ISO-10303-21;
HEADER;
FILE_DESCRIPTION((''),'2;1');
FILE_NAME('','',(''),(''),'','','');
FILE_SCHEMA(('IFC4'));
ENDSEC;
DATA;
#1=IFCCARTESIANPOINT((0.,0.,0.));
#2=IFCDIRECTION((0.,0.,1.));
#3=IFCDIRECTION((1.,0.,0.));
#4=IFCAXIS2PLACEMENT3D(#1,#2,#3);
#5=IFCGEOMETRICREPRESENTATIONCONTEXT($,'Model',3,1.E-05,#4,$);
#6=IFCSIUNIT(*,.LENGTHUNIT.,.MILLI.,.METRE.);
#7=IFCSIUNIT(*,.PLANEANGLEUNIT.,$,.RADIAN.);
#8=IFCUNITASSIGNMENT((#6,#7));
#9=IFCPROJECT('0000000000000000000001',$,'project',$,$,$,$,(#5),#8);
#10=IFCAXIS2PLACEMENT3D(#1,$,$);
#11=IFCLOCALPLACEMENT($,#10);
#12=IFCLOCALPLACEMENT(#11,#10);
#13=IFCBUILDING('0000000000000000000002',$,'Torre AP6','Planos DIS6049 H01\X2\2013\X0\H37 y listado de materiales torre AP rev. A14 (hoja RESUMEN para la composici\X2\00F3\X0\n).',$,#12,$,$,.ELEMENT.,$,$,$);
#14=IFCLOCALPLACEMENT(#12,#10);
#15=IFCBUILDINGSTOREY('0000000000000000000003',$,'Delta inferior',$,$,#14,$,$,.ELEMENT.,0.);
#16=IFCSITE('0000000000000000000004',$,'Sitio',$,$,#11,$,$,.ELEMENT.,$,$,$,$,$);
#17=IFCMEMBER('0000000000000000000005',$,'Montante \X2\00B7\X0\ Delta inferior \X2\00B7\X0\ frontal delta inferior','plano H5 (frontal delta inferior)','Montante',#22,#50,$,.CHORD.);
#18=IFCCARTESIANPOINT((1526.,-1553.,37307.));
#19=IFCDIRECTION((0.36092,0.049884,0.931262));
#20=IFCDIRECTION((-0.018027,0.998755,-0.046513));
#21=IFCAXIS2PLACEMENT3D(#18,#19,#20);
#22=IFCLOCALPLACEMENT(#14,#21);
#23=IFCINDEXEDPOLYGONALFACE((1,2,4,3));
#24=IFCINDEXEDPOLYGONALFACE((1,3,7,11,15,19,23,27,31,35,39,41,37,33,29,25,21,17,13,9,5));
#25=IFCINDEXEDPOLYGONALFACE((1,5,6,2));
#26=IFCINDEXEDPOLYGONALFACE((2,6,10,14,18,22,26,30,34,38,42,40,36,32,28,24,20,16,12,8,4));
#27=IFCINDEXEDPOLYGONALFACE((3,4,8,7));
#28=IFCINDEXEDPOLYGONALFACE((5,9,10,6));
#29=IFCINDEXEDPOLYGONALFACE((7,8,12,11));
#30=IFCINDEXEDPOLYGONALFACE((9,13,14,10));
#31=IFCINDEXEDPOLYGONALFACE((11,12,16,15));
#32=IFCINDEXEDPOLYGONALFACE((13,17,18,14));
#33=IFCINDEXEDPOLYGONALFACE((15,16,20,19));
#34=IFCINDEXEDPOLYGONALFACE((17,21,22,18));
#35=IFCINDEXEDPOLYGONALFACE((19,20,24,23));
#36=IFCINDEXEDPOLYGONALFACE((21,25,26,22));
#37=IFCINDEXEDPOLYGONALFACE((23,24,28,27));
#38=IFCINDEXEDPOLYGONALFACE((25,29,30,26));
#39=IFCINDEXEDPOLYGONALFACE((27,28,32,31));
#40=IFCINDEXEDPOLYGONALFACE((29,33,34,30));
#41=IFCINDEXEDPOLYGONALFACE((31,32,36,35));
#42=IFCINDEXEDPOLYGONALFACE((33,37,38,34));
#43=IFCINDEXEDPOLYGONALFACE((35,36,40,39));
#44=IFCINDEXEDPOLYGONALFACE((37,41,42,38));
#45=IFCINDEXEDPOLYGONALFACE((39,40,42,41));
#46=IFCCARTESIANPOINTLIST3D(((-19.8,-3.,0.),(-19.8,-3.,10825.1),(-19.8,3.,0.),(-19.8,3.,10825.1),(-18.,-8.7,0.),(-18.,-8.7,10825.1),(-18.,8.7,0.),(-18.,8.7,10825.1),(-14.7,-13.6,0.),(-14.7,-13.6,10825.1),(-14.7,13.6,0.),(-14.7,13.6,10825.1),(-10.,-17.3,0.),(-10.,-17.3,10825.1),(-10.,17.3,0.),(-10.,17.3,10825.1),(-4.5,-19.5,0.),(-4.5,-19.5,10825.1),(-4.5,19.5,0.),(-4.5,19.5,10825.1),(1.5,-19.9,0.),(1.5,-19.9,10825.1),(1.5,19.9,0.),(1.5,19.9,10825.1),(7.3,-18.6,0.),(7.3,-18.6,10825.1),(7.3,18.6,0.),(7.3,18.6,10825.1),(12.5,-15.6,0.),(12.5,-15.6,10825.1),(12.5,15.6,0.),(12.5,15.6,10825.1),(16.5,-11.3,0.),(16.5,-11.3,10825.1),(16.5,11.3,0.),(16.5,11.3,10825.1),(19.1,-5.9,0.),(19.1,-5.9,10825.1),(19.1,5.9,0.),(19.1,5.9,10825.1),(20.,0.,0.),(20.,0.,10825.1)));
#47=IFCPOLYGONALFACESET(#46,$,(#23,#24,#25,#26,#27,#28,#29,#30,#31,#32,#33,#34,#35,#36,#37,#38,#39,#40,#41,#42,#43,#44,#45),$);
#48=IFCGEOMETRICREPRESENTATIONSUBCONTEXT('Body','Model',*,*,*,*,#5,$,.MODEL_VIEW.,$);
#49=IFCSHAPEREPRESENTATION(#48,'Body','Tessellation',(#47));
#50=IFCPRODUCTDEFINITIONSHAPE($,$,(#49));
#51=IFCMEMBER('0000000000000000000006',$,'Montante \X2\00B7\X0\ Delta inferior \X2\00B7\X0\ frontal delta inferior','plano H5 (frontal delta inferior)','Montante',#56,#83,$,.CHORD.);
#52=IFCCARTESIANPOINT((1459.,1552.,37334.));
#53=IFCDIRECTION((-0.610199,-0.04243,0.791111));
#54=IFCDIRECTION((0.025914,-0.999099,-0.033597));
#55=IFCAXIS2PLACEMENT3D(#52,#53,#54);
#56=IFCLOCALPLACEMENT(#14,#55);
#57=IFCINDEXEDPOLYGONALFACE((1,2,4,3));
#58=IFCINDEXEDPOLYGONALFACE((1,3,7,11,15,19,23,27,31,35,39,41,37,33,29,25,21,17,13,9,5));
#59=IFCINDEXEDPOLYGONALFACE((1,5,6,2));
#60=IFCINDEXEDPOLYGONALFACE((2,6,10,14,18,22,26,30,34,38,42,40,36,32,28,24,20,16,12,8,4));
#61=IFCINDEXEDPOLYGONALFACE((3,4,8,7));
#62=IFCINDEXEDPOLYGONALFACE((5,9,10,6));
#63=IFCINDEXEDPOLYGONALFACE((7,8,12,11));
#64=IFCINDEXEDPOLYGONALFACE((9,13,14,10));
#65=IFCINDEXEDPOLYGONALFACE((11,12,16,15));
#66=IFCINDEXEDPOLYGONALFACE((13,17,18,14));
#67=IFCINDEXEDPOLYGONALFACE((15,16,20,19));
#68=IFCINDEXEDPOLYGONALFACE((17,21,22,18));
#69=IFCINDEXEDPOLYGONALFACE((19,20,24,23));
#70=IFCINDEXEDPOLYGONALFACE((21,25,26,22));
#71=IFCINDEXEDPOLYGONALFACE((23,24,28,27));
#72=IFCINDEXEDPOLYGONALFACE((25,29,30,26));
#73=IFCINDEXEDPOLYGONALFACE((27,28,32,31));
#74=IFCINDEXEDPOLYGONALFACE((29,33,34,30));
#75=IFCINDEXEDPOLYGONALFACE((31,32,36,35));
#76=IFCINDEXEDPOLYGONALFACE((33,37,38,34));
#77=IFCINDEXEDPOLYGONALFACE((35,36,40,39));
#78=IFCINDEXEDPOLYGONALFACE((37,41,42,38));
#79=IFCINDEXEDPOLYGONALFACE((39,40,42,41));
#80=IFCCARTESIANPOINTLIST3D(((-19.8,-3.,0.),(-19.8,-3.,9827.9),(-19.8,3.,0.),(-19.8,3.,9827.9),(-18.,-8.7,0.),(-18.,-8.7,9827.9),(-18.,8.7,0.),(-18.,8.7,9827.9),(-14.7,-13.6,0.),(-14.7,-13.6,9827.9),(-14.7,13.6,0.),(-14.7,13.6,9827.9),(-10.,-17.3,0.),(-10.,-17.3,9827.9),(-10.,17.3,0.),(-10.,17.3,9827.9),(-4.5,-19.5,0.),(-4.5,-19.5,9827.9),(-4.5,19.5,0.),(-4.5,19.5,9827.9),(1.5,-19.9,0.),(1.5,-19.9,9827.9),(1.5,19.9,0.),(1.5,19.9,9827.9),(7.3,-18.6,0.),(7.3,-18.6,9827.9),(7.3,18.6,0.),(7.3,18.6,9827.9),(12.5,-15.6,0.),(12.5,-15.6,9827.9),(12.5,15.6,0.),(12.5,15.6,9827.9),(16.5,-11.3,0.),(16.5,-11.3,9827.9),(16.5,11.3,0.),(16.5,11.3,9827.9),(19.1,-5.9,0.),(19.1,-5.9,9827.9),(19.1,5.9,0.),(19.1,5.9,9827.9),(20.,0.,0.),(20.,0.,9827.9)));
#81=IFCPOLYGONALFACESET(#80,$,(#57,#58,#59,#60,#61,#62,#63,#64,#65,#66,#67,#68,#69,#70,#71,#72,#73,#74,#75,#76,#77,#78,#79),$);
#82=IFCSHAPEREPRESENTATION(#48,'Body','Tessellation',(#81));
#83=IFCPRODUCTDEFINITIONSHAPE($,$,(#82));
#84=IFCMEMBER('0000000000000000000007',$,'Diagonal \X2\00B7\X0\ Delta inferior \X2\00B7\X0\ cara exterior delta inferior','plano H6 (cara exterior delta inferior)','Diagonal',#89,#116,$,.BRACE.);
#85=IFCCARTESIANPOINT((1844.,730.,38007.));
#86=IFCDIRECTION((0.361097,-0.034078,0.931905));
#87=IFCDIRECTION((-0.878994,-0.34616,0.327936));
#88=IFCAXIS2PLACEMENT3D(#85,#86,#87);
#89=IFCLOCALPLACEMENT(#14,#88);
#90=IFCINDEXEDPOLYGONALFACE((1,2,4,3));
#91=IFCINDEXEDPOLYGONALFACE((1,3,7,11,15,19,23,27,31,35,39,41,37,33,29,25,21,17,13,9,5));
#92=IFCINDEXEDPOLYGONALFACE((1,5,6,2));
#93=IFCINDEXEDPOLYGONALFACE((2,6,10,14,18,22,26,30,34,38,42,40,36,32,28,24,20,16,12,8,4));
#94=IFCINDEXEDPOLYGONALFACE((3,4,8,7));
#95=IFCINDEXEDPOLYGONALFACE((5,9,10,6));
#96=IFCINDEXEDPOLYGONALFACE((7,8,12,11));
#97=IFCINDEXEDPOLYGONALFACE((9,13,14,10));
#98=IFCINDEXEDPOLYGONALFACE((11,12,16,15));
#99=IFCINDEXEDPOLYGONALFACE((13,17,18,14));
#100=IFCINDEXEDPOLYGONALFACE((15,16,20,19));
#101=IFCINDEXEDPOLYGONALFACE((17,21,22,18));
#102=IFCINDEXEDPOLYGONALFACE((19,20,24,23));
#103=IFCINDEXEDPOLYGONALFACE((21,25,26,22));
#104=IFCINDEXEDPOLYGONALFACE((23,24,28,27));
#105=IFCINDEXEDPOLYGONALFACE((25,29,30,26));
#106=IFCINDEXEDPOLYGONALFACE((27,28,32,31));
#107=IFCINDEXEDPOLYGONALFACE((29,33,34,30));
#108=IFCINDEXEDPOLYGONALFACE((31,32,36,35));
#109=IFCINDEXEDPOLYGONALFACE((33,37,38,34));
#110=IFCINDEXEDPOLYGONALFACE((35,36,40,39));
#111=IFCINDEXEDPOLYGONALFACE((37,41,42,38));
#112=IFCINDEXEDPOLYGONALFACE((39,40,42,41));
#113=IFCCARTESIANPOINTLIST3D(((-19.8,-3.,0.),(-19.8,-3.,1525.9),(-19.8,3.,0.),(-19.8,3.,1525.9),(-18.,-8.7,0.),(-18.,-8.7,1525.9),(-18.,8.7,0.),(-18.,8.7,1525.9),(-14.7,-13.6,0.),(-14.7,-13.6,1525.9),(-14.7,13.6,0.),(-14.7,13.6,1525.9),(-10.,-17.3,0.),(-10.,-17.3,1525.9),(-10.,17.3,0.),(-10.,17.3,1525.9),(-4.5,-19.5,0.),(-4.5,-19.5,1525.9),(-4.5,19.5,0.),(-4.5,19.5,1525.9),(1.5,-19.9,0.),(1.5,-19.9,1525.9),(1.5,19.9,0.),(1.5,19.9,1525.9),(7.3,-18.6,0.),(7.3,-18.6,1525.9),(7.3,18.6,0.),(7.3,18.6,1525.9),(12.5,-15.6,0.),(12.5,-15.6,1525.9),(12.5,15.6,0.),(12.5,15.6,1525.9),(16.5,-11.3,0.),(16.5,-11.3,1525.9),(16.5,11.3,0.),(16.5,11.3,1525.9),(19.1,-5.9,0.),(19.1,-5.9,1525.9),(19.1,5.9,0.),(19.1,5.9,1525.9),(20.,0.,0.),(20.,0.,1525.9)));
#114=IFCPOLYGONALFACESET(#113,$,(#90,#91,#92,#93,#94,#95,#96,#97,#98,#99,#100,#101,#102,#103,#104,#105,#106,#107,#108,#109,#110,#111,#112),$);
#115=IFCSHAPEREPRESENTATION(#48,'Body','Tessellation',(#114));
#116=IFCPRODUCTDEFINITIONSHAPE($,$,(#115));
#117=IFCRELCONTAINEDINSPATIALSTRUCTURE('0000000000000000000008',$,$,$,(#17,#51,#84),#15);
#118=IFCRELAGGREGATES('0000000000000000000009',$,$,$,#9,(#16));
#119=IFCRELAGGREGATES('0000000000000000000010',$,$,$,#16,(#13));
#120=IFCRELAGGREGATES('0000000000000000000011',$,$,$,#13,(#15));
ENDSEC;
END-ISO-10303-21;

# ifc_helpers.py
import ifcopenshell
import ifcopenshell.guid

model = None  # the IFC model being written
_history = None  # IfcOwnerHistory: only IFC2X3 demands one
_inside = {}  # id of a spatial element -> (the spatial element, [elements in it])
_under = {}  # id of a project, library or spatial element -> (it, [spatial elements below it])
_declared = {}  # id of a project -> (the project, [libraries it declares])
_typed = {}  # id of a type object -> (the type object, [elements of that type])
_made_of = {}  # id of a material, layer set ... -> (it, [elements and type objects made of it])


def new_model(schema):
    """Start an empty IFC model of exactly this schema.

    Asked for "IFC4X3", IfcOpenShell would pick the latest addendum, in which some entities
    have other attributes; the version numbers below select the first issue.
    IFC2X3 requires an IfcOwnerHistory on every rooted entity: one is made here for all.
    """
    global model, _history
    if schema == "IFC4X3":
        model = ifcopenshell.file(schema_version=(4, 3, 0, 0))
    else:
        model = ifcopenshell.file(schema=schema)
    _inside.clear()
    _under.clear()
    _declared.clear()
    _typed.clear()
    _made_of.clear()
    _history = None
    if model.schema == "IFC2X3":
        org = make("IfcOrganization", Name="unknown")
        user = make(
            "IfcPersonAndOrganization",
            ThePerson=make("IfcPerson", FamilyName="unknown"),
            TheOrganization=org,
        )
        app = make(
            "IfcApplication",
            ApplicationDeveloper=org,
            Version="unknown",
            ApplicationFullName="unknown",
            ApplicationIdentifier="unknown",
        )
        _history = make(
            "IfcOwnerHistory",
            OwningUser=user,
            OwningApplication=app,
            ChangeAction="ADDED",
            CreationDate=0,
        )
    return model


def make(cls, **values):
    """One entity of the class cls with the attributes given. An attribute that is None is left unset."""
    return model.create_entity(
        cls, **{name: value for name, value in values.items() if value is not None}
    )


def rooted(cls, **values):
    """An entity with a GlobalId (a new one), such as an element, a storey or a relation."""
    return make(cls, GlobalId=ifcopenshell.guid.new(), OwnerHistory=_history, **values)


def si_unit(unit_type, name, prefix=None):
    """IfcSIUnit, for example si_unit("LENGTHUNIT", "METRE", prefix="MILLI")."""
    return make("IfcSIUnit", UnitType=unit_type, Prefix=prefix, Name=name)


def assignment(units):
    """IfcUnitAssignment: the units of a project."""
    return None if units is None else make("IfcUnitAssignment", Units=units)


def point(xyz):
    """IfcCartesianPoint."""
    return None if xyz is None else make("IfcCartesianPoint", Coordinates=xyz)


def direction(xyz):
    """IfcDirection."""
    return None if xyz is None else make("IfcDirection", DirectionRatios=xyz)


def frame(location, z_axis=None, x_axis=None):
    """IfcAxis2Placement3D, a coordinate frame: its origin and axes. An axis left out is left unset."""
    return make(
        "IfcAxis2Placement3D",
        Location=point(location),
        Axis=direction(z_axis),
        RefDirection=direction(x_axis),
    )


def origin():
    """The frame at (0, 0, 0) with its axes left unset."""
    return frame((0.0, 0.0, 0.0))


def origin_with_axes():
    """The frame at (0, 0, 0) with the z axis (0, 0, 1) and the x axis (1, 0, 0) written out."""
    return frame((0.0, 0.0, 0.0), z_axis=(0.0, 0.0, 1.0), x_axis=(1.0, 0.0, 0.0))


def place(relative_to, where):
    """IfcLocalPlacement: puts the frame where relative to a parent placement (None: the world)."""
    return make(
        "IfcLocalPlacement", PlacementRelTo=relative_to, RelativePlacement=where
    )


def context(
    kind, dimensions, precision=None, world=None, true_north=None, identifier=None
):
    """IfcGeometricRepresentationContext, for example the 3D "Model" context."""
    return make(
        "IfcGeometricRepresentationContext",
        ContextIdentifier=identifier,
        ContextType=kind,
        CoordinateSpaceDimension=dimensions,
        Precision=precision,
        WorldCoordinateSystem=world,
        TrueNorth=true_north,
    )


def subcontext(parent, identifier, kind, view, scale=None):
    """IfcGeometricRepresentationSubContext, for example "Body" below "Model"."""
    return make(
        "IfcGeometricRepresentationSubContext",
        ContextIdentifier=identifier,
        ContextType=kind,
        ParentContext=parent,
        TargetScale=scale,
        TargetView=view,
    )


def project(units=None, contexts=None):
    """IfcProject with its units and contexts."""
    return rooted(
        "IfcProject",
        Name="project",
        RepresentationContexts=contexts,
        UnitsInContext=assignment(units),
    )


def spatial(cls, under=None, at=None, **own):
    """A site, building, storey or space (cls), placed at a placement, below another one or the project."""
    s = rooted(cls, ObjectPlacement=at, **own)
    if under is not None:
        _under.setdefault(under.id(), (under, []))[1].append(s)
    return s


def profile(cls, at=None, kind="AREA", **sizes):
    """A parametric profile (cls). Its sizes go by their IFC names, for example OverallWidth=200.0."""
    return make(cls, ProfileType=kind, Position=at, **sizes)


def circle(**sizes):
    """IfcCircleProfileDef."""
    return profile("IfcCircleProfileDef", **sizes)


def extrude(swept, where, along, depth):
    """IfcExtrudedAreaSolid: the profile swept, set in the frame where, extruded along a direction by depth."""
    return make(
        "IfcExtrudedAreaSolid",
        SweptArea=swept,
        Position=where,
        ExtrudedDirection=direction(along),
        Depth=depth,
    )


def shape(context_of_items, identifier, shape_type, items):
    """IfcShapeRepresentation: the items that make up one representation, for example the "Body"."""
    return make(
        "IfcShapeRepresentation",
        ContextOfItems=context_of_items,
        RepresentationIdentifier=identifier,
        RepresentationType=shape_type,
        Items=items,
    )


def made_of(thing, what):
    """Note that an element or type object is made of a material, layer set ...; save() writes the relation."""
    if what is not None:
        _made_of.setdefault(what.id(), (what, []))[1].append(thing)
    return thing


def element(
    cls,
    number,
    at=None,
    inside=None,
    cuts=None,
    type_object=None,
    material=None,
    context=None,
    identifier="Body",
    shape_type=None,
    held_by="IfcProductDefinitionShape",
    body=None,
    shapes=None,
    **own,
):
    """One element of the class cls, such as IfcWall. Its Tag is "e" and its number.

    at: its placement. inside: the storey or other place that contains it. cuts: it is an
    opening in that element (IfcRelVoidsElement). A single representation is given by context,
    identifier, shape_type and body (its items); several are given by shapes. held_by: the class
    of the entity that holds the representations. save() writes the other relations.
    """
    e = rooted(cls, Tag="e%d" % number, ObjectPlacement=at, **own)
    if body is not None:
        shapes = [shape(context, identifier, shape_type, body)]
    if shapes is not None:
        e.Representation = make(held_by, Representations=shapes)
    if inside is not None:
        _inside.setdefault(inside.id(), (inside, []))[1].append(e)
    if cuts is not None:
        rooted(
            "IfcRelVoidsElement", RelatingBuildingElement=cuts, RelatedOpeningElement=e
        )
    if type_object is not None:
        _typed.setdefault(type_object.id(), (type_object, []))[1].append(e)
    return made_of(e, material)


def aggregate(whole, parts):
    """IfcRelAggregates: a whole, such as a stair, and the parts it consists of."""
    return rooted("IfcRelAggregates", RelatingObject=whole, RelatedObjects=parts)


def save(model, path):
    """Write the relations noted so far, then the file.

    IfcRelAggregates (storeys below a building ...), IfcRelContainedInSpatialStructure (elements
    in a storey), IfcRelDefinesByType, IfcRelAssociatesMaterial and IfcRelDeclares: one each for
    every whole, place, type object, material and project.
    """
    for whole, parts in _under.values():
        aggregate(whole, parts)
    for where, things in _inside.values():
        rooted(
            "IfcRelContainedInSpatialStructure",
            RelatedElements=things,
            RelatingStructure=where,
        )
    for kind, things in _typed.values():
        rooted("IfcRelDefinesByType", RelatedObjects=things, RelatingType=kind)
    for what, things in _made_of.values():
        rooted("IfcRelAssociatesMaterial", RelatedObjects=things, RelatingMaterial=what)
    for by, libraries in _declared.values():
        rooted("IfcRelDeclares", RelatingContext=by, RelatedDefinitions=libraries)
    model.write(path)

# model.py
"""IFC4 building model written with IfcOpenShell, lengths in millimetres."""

from ifc_helpers import new_model, si_unit, frame, origin, origin_with_axes, place, context, subcontext, project, spatial, circle, extrude, element, save


model = new_model("IFC4")

# Units and contexts
model_context = context("Model", 3, precision=1e-05, world=origin_with_axes())
body_context = subcontext(model_context, "Body", "Model", "MODEL_VIEW")
ifc_project = project(units=[si_unit("LENGTHUNIT", "METRE", prefix="MILLI"), si_unit("PLANEANGLEUNIT", "RADIAN")], contexts=[model_context])

# Site, building, storey
site_placement = place(None, origin())
site = spatial("IfcSite", under=ifc_project, at=site_placement, Name="Sitio", CompositionType="ELEMENT")
building_placement = place(site_placement, origin())
building = spatial("IfcBuilding", under=site, at=building_placement, Name="Torre AP6", Description="Planos DIS6049 H01–H37 y listado de materiales torre AP rev. A14 (hoja RESUMEN para la composición).", CompositionType="ELEMENT")
storey_placement = place(building_placement, origin())
storey = spatial("IfcBuildingStorey", under=building, at=storey_placement, Name="Delta inferior", CompositionType="ELEMENT", Elevation=0.0)

# Members
for number, where, z_axis, x_axis, name in (
    (1, (1526.0, -1553.0, 37307.0), (0.36092, 0.049884, 0.931262), (-0.018027, 0.998755, -0.046513), "Montante · Delta inferior · frontal delta inferior"),
):
    element("IfcMember", number, at=place(storey_placement, frame(where, z_axis=z_axis, x_axis=x_axis)), inside=storey, Name=name, Description="plano H5 (frontal delta inferior)", ObjectType="Montante", PredefinedType="CHORD", context=body_context, shape_type="SweptSolid", body=[
        extrude(circle(Radius=20.0), None, (0.0, 0.0, 1.0), 10825.1),
    ])
for number, where, z_axis, x_axis, name in (
    (2, (1459.0, 1552.0, 37334.0), (-0.610199, -0.04243, 0.791111), (0.025914, -0.999099, -0.033597), "Montante · Delta inferior · frontal delta inferior"),
):
    element("IfcMember", number, at=place(storey_placement, frame(where, z_axis=z_axis, x_axis=x_axis)), inside=storey, Name=name, Description="plano H5 (frontal delta inferior)", ObjectType="Montante", PredefinedType="CHORD", context=body_context, shape_type="SweptSolid", body=[
        extrude(circle(Radius=20.0), None, (0.0, 0.0, 1.0), 9827.9),
    ])
member_1_placement = place(storey_placement, frame((1844.0, 730.0, 38007.0), z_axis=(0.361097, -0.034078, 0.931905), x_axis=(-0.878994, -0.34616, 0.327936)))
element("IfcMember", 3, at=member_1_placement, inside=storey, Name="Diagonal · Delta inferior · cara exterior delta inferior", Description="plano H6 (cara exterior delta inferior)", ObjectType="Diagonal", PredefinedType="BRACE", context=body_context, shape_type="SweptSolid", body=[
    extrude(circle(Radius=20.0), None, (0.0, 0.0, 1.0), 1525.9),
])

save(model, "model.ifc")
